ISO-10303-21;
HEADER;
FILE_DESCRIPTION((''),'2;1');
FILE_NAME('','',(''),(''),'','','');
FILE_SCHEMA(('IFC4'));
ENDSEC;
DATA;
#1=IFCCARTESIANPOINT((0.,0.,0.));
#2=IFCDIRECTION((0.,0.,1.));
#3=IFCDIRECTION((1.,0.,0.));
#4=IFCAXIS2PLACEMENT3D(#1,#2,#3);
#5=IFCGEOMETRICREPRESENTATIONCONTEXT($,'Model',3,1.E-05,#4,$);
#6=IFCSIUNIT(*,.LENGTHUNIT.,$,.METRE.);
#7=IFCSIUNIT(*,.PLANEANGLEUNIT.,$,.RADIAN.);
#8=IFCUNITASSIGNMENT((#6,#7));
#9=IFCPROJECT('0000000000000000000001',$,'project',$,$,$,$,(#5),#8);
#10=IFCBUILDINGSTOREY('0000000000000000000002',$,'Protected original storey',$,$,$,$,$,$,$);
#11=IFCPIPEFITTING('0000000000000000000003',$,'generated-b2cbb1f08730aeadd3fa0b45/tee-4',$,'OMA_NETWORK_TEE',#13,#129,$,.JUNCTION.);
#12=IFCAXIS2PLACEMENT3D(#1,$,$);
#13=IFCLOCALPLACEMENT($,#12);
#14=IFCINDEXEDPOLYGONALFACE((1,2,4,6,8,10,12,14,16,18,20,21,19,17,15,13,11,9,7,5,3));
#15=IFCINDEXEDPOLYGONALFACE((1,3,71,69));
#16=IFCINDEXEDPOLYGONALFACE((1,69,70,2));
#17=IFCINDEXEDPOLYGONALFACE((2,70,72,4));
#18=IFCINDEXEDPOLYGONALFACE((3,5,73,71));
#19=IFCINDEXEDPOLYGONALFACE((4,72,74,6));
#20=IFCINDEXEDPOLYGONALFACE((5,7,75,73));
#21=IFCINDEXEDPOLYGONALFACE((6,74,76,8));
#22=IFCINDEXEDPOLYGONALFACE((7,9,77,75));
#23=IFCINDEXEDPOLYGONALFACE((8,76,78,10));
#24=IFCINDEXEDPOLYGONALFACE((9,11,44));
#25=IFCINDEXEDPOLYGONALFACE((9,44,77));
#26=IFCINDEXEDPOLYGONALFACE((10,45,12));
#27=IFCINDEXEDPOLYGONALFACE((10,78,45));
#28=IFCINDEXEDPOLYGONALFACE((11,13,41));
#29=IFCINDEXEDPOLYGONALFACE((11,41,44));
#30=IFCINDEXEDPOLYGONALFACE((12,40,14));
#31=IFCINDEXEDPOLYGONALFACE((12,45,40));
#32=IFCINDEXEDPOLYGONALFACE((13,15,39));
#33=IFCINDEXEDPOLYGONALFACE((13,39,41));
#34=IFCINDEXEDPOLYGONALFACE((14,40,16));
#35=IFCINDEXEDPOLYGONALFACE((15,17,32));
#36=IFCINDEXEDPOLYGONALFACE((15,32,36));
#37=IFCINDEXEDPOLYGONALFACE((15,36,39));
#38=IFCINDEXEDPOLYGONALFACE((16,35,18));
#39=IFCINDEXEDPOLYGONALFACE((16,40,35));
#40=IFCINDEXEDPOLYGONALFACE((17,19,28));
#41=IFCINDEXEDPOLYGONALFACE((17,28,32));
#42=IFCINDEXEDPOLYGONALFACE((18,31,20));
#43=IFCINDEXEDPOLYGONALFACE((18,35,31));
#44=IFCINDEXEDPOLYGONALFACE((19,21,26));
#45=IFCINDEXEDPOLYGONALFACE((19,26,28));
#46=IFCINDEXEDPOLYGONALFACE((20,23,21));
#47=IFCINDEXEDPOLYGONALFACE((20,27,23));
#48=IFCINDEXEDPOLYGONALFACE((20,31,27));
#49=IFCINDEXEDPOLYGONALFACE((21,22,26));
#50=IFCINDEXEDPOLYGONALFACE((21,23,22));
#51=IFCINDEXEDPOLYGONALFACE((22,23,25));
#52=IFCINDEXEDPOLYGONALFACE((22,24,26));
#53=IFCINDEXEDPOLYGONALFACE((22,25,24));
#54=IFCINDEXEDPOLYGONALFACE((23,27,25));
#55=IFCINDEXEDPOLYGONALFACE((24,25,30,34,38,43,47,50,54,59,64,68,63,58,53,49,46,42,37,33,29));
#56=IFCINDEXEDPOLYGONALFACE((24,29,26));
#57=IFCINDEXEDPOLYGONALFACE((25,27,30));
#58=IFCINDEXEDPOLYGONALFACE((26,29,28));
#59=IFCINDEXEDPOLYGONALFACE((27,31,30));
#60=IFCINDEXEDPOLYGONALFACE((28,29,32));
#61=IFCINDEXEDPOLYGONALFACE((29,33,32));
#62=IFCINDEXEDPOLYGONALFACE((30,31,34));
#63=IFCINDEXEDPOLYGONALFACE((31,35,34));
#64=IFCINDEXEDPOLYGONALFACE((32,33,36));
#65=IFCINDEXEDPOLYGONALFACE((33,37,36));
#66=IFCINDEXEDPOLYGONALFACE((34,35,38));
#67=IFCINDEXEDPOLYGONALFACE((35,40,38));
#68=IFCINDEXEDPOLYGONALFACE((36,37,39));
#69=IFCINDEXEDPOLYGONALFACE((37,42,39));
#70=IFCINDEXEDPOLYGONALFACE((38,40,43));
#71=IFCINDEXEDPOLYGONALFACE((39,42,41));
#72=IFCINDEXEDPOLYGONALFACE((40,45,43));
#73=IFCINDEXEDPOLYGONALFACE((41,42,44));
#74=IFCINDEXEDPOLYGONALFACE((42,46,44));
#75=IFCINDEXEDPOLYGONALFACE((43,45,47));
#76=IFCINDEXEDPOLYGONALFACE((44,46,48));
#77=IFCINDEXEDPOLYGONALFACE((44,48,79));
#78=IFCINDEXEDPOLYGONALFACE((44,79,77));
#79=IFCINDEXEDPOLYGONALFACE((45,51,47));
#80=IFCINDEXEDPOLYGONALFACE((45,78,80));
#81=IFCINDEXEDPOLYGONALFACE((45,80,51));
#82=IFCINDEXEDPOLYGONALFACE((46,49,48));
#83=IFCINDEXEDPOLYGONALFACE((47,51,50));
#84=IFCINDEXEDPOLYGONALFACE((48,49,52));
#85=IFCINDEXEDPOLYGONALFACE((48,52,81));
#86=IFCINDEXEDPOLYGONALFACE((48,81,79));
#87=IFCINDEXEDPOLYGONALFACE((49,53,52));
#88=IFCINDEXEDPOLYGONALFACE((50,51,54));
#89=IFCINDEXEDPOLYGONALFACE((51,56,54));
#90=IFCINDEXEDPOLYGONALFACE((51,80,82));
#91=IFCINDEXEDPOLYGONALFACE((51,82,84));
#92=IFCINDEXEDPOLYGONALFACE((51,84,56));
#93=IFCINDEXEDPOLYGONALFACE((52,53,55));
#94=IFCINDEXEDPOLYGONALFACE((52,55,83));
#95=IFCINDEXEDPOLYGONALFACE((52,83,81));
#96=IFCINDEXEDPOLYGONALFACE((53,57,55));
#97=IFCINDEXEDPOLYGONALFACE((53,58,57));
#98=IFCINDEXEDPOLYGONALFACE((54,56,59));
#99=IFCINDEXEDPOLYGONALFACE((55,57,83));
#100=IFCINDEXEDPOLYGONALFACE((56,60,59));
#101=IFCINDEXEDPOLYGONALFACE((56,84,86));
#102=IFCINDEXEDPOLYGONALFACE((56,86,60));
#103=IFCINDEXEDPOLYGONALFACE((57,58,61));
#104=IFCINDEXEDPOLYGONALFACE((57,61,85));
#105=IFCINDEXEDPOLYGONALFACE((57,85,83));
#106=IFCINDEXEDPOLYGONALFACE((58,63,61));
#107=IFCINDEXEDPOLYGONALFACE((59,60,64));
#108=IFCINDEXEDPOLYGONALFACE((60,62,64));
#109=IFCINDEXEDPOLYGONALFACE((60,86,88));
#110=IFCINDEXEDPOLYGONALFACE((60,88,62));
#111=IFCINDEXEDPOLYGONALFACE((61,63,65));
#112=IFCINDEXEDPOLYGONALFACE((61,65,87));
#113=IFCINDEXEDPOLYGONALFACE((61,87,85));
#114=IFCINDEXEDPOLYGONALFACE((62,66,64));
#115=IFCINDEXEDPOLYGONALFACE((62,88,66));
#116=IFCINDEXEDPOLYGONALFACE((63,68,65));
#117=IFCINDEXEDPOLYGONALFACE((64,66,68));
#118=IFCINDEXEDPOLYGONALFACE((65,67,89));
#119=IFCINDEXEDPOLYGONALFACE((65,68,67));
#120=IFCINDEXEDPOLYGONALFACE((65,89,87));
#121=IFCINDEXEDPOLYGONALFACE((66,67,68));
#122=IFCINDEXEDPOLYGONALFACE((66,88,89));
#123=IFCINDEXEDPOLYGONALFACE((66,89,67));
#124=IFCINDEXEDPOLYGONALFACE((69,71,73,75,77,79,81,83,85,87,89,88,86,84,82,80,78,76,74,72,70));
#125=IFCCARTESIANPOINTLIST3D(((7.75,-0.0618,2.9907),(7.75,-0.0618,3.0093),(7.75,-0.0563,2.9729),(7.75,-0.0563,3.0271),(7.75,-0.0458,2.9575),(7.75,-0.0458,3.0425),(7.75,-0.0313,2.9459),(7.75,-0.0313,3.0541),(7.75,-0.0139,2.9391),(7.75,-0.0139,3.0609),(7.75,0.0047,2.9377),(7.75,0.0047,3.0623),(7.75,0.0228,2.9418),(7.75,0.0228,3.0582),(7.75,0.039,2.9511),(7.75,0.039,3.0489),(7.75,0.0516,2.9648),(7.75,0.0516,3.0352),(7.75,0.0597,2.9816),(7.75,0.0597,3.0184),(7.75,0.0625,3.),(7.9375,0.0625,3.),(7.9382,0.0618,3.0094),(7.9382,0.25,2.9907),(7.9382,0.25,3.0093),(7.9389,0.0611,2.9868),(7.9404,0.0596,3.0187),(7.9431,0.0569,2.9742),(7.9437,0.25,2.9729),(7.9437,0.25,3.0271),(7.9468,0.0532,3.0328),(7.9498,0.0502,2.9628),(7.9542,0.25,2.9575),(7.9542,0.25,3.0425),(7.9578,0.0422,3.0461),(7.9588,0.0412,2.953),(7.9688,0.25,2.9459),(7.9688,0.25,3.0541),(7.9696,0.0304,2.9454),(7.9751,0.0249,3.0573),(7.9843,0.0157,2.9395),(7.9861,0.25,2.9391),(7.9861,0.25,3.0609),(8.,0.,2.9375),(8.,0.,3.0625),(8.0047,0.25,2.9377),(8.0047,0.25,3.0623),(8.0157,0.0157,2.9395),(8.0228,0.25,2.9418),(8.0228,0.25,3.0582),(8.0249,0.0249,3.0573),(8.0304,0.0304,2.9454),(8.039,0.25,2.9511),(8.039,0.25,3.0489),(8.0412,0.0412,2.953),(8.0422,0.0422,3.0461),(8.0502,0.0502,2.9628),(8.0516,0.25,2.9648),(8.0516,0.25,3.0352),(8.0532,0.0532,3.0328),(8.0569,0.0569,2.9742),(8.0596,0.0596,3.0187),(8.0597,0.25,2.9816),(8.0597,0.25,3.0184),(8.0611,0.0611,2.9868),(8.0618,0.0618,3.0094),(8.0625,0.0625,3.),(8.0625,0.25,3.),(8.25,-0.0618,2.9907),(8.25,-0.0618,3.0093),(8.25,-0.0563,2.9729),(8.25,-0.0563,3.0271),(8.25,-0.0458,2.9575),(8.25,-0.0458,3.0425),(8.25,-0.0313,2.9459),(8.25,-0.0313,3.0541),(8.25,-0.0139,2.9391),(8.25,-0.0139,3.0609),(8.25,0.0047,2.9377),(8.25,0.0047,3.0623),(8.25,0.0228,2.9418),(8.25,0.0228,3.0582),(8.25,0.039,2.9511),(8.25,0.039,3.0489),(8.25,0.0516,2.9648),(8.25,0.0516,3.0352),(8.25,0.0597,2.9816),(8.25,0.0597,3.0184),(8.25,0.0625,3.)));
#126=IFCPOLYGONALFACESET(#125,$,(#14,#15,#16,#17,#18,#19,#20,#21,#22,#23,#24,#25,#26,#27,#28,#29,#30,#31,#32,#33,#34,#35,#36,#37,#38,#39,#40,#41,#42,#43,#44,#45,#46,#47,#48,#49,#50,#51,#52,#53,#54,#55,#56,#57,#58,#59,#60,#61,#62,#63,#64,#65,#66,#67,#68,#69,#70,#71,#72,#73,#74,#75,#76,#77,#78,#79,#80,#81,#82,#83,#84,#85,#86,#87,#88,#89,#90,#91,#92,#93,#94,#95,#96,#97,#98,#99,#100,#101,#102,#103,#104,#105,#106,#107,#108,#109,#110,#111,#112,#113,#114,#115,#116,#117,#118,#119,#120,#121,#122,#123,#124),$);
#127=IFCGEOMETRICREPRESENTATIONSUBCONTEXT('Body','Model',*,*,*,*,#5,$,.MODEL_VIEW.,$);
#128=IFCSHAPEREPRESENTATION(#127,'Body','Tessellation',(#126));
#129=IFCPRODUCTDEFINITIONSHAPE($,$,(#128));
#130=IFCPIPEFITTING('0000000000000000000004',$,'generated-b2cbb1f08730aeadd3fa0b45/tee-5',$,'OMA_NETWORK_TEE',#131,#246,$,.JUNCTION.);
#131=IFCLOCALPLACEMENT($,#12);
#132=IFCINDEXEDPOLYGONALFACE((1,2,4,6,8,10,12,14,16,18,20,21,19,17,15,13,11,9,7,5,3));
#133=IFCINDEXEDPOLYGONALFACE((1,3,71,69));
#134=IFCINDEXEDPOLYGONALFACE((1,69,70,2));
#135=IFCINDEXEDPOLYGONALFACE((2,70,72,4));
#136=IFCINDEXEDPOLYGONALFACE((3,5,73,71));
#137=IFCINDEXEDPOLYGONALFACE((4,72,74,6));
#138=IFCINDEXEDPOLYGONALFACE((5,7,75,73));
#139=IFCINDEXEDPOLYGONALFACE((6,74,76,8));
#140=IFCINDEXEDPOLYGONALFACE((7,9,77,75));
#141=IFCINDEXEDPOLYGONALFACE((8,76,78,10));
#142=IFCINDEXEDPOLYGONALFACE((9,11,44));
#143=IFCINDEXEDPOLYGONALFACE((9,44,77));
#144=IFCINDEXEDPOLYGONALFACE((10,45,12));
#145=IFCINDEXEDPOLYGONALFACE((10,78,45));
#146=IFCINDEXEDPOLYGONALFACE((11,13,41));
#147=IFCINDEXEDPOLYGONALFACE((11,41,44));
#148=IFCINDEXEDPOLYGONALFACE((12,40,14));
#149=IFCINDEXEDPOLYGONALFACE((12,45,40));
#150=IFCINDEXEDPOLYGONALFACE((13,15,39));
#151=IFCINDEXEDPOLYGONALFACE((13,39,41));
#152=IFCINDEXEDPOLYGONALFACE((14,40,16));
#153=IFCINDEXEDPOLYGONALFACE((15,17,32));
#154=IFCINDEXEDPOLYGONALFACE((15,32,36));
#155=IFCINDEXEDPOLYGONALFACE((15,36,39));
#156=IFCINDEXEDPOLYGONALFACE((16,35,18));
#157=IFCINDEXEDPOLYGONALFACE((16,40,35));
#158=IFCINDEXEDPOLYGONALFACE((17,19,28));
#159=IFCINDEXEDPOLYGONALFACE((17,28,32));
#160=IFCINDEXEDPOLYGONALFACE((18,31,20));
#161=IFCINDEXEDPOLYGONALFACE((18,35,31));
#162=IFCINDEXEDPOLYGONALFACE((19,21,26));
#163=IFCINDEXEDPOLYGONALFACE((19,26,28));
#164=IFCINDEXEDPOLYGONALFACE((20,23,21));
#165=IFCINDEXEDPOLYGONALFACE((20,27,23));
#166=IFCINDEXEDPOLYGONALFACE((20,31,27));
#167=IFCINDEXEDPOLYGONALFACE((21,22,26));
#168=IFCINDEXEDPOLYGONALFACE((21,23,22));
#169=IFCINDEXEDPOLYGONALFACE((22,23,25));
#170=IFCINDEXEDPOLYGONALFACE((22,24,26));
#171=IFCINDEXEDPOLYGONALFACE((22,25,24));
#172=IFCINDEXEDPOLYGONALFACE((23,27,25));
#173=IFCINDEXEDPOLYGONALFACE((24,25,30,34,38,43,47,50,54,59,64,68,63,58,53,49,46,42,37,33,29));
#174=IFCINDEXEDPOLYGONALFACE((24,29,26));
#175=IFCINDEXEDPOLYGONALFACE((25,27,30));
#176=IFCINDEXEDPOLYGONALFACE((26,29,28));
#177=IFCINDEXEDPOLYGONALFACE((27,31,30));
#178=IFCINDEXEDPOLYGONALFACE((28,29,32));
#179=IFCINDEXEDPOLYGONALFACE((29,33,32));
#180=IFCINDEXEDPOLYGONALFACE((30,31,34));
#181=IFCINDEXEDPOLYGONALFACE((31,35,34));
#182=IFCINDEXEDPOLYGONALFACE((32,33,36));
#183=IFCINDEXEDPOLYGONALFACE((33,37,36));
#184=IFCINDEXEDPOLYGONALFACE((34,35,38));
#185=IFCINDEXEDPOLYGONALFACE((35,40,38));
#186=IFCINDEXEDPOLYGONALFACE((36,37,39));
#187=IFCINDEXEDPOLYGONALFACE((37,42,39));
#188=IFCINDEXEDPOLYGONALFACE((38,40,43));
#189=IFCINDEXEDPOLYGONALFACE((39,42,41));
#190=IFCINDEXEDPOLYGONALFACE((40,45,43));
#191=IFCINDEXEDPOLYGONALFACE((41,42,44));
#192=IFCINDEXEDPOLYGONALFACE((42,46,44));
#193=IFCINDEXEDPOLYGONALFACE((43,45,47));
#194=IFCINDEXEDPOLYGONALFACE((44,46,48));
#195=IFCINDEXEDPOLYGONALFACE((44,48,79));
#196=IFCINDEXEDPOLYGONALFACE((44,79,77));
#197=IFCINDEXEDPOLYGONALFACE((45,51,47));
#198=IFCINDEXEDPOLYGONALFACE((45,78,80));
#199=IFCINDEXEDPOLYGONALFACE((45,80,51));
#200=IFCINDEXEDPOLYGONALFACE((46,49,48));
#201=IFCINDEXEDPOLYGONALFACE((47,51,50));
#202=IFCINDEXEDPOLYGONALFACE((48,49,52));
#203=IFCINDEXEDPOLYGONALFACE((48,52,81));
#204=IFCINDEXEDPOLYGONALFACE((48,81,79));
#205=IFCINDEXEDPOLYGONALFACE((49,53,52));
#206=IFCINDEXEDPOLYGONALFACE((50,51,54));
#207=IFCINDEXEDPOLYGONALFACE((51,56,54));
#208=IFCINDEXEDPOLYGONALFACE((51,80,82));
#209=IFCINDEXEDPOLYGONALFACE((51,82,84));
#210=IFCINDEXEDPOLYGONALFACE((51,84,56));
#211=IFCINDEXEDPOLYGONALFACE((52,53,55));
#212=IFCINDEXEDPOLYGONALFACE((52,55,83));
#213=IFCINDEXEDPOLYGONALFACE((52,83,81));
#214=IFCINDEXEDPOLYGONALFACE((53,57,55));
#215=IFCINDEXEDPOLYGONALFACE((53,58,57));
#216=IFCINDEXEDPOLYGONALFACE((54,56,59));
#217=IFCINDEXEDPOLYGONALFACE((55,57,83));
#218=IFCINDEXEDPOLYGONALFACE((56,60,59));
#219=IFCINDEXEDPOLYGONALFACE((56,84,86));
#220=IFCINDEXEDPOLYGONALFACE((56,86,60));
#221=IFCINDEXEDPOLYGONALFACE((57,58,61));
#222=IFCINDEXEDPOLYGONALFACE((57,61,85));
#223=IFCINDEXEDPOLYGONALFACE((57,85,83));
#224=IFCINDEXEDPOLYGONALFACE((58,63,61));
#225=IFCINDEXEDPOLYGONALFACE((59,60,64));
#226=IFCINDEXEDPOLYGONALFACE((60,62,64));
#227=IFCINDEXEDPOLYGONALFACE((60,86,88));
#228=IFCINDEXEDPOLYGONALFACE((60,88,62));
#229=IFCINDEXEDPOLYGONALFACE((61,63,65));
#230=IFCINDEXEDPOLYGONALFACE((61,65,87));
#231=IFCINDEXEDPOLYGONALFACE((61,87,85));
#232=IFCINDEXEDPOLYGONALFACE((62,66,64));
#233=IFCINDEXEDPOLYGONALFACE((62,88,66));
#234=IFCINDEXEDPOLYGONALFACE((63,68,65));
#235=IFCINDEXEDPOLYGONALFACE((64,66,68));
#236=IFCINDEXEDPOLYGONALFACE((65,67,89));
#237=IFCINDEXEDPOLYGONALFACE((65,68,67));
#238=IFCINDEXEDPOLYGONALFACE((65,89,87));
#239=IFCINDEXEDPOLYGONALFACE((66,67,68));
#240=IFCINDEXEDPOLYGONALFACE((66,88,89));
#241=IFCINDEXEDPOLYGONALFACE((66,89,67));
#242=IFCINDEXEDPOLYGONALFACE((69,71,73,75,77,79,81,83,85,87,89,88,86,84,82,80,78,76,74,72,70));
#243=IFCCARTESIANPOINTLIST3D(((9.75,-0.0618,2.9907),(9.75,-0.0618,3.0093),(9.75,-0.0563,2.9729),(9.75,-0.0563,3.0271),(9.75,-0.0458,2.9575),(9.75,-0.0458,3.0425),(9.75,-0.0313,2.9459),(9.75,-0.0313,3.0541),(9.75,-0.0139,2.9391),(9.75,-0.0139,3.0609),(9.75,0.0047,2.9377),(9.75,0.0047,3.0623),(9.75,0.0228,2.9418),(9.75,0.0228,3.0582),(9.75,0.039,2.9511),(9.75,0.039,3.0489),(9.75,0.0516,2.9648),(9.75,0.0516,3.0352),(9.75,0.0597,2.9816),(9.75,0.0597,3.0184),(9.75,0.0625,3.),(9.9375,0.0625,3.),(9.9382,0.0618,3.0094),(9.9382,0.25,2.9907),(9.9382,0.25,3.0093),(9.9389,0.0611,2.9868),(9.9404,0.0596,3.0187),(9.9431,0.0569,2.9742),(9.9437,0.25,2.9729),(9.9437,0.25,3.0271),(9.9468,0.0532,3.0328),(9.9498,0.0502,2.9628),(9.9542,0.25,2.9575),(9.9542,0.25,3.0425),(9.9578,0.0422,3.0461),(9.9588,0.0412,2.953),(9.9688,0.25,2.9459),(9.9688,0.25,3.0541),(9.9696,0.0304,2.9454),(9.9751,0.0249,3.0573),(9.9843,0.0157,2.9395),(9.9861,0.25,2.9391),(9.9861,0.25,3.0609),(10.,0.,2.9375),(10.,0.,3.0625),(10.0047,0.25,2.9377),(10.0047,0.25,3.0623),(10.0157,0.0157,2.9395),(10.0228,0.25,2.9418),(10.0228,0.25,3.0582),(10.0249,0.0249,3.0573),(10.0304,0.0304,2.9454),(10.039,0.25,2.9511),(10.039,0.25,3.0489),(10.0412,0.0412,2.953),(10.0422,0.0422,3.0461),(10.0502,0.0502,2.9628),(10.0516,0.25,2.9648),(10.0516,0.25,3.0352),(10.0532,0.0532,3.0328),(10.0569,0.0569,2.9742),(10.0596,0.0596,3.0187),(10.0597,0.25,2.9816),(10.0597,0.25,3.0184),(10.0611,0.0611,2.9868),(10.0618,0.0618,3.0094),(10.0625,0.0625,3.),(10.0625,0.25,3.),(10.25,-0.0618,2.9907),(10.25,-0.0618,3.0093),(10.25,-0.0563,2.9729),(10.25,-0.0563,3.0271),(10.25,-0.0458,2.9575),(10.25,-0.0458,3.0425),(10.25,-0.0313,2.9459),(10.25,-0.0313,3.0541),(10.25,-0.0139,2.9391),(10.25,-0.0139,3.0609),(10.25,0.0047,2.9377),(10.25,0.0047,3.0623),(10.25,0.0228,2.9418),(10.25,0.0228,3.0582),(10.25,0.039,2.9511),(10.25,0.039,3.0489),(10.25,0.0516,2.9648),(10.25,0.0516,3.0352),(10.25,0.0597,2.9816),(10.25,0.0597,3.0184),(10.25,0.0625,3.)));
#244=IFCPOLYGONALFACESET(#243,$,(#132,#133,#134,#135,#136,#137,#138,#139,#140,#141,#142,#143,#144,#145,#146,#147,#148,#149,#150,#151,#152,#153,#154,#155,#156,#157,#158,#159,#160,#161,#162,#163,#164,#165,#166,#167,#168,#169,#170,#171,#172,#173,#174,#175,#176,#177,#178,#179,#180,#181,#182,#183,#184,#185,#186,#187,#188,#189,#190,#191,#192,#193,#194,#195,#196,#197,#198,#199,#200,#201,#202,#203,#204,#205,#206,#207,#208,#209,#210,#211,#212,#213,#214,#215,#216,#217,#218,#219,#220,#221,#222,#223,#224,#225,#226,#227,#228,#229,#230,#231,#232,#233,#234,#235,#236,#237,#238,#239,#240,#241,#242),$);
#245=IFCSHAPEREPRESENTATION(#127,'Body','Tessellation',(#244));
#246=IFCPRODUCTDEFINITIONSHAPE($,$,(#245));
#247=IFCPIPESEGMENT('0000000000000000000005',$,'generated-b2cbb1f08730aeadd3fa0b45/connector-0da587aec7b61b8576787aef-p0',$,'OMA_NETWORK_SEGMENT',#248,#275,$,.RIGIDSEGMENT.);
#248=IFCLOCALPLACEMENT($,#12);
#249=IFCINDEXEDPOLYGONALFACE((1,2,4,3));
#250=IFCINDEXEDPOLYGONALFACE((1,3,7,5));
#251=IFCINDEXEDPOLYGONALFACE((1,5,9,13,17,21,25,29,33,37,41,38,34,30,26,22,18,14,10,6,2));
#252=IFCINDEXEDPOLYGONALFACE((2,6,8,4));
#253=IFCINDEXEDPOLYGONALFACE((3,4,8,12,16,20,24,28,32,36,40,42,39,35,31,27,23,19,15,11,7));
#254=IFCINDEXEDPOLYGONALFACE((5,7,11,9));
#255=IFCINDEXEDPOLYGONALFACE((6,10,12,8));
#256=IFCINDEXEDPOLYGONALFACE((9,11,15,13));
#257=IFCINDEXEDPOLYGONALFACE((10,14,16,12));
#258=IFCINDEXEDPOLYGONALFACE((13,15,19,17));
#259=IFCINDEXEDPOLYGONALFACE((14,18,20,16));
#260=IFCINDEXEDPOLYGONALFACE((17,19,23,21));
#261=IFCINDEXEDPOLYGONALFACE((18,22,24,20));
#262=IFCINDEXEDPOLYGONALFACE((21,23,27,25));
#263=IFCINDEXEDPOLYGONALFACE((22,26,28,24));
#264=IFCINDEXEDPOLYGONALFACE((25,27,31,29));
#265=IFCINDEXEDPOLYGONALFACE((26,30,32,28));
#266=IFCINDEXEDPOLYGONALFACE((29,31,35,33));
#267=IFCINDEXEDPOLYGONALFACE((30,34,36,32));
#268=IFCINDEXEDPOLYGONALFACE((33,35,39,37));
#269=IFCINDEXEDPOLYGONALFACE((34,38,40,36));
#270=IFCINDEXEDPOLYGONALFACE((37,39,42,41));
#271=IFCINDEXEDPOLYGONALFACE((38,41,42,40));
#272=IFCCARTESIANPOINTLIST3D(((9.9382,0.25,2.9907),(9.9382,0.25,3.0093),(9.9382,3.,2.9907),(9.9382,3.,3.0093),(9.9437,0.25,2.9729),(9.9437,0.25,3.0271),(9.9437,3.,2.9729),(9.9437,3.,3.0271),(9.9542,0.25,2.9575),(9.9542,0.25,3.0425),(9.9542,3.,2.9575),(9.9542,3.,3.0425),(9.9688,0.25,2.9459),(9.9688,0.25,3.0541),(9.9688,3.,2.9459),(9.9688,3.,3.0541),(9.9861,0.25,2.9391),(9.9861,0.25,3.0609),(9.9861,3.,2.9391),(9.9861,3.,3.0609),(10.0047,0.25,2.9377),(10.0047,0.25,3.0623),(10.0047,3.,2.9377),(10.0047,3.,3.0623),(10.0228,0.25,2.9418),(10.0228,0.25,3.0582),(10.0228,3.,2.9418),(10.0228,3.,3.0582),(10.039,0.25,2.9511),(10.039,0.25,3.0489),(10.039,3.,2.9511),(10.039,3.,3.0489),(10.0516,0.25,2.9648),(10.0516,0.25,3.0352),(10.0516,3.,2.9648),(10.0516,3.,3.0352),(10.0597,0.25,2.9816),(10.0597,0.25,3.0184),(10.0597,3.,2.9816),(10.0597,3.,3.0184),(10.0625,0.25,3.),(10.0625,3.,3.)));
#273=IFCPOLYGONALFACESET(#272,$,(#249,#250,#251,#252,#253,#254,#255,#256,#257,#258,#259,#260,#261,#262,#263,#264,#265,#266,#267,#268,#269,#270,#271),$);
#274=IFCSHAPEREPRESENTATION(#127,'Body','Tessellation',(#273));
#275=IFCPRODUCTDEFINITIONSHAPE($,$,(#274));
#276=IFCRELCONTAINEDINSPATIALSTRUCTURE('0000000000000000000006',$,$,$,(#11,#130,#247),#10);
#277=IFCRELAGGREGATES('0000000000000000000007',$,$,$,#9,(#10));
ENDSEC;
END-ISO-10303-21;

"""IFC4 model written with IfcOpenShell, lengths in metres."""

from ifc_helpers import new_model, si_unit, frame, origin_with_axes, origin_2d, place, context, subcontext, project, spatial, circle, extrude, boolean, element, save


model = new_model("IFC4")

# Units and contexts
model_context = context("Model", 3, precision=1e-05, world=origin_with_axes())
body_context = subcontext(model_context, "Body", "Model", "MODEL_VIEW")
ifc_project = project(units=[si_unit("LENGTHUNIT", "METRE"), si_unit("PLANEANGLEUNIT", "RADIAN")], contexts=[model_context])

# Storey
storey = spatial("IfcBuildingStorey", under=ifc_project, Name="Protected original storey")

# Pipe fittings
pipe_fitting_1_placement = place(None, origin_with_axes())
element("IfcPipeFitting", 1, at=pipe_fitting_1_placement, inside=storey, Name="generated-b2cbb1f08730aeadd3fa0b45/tee-4", ObjectType="OMA_NETWORK_TEE", PredefinedType="JUNCTION", context=body_context, shape_type="CSG", body=[
    boolean("UNION", extrude(circle(Radius=0.0625, at=origin_2d()), frame((7.75, 0.0, 3.0), z_axis=(1.0, 0.0, 0.0), x_axis=(0.0, 1.0, 0.0)), (0.0, 0.0, 1.0), 0.5), extrude(circle(Radius=0.0625, at=origin_2d()), frame((8.0, 0.0, 3.0), z_axis=(0.0, 1.0, 0.0), x_axis=(1.0, 0.0, 0.0)), (0.0, 0.0, 1.0), 0.25)),
])
pipe_fitting_2_placement = place(None, origin_with_axes())
element("IfcPipeFitting", 2, at=pipe_fitting_2_placement, inside=storey, Name="generated-b2cbb1f08730aeadd3fa0b45/tee-5", ObjectType="OMA_NETWORK_TEE", PredefinedType="JUNCTION", context=body_context, shape_type="CSG", body=[
    boolean("UNION", extrude(circle(Radius=0.0625, at=origin_2d()), frame((9.75, 0.0, 3.0), z_axis=(1.0, 0.0, 0.0), x_axis=(0.0, 1.0, 0.0)), (0.0, 0.0, 1.0), 0.5), extrude(circle(Radius=0.0625, at=origin_2d()), frame((10.0, 0.0, 3.0), z_axis=(0.0, 1.0, 0.0), x_axis=(1.0, 0.0, 0.0)), (0.0, 0.0, 1.0), 0.25)),
])

# Pipe segment
pipe_segment_1_placement = place(None, origin_with_axes())
element("IfcPipeSegment", 3, at=pipe_segment_1_placement, inside=storey, Name="generated-b2cbb1f08730aeadd3fa0b45/connector-0da587aec7b61b8576787aef-p0", ObjectType="OMA_NETWORK_SEGMENT", PredefinedType="RIGIDSEGMENT", context=body_context, shape_type="SweptSolid", body=[
    extrude(circle(Radius=0.0625, at=origin_2d()), frame((10.0, 0.25, 3.0), z_axis=(0.0, 1.0, 0.0), x_axis=(1.0, 0.0, 0.0)), (0.0, 0.0, 1.0), 2.75),
])

save(model, "model.ifc")
